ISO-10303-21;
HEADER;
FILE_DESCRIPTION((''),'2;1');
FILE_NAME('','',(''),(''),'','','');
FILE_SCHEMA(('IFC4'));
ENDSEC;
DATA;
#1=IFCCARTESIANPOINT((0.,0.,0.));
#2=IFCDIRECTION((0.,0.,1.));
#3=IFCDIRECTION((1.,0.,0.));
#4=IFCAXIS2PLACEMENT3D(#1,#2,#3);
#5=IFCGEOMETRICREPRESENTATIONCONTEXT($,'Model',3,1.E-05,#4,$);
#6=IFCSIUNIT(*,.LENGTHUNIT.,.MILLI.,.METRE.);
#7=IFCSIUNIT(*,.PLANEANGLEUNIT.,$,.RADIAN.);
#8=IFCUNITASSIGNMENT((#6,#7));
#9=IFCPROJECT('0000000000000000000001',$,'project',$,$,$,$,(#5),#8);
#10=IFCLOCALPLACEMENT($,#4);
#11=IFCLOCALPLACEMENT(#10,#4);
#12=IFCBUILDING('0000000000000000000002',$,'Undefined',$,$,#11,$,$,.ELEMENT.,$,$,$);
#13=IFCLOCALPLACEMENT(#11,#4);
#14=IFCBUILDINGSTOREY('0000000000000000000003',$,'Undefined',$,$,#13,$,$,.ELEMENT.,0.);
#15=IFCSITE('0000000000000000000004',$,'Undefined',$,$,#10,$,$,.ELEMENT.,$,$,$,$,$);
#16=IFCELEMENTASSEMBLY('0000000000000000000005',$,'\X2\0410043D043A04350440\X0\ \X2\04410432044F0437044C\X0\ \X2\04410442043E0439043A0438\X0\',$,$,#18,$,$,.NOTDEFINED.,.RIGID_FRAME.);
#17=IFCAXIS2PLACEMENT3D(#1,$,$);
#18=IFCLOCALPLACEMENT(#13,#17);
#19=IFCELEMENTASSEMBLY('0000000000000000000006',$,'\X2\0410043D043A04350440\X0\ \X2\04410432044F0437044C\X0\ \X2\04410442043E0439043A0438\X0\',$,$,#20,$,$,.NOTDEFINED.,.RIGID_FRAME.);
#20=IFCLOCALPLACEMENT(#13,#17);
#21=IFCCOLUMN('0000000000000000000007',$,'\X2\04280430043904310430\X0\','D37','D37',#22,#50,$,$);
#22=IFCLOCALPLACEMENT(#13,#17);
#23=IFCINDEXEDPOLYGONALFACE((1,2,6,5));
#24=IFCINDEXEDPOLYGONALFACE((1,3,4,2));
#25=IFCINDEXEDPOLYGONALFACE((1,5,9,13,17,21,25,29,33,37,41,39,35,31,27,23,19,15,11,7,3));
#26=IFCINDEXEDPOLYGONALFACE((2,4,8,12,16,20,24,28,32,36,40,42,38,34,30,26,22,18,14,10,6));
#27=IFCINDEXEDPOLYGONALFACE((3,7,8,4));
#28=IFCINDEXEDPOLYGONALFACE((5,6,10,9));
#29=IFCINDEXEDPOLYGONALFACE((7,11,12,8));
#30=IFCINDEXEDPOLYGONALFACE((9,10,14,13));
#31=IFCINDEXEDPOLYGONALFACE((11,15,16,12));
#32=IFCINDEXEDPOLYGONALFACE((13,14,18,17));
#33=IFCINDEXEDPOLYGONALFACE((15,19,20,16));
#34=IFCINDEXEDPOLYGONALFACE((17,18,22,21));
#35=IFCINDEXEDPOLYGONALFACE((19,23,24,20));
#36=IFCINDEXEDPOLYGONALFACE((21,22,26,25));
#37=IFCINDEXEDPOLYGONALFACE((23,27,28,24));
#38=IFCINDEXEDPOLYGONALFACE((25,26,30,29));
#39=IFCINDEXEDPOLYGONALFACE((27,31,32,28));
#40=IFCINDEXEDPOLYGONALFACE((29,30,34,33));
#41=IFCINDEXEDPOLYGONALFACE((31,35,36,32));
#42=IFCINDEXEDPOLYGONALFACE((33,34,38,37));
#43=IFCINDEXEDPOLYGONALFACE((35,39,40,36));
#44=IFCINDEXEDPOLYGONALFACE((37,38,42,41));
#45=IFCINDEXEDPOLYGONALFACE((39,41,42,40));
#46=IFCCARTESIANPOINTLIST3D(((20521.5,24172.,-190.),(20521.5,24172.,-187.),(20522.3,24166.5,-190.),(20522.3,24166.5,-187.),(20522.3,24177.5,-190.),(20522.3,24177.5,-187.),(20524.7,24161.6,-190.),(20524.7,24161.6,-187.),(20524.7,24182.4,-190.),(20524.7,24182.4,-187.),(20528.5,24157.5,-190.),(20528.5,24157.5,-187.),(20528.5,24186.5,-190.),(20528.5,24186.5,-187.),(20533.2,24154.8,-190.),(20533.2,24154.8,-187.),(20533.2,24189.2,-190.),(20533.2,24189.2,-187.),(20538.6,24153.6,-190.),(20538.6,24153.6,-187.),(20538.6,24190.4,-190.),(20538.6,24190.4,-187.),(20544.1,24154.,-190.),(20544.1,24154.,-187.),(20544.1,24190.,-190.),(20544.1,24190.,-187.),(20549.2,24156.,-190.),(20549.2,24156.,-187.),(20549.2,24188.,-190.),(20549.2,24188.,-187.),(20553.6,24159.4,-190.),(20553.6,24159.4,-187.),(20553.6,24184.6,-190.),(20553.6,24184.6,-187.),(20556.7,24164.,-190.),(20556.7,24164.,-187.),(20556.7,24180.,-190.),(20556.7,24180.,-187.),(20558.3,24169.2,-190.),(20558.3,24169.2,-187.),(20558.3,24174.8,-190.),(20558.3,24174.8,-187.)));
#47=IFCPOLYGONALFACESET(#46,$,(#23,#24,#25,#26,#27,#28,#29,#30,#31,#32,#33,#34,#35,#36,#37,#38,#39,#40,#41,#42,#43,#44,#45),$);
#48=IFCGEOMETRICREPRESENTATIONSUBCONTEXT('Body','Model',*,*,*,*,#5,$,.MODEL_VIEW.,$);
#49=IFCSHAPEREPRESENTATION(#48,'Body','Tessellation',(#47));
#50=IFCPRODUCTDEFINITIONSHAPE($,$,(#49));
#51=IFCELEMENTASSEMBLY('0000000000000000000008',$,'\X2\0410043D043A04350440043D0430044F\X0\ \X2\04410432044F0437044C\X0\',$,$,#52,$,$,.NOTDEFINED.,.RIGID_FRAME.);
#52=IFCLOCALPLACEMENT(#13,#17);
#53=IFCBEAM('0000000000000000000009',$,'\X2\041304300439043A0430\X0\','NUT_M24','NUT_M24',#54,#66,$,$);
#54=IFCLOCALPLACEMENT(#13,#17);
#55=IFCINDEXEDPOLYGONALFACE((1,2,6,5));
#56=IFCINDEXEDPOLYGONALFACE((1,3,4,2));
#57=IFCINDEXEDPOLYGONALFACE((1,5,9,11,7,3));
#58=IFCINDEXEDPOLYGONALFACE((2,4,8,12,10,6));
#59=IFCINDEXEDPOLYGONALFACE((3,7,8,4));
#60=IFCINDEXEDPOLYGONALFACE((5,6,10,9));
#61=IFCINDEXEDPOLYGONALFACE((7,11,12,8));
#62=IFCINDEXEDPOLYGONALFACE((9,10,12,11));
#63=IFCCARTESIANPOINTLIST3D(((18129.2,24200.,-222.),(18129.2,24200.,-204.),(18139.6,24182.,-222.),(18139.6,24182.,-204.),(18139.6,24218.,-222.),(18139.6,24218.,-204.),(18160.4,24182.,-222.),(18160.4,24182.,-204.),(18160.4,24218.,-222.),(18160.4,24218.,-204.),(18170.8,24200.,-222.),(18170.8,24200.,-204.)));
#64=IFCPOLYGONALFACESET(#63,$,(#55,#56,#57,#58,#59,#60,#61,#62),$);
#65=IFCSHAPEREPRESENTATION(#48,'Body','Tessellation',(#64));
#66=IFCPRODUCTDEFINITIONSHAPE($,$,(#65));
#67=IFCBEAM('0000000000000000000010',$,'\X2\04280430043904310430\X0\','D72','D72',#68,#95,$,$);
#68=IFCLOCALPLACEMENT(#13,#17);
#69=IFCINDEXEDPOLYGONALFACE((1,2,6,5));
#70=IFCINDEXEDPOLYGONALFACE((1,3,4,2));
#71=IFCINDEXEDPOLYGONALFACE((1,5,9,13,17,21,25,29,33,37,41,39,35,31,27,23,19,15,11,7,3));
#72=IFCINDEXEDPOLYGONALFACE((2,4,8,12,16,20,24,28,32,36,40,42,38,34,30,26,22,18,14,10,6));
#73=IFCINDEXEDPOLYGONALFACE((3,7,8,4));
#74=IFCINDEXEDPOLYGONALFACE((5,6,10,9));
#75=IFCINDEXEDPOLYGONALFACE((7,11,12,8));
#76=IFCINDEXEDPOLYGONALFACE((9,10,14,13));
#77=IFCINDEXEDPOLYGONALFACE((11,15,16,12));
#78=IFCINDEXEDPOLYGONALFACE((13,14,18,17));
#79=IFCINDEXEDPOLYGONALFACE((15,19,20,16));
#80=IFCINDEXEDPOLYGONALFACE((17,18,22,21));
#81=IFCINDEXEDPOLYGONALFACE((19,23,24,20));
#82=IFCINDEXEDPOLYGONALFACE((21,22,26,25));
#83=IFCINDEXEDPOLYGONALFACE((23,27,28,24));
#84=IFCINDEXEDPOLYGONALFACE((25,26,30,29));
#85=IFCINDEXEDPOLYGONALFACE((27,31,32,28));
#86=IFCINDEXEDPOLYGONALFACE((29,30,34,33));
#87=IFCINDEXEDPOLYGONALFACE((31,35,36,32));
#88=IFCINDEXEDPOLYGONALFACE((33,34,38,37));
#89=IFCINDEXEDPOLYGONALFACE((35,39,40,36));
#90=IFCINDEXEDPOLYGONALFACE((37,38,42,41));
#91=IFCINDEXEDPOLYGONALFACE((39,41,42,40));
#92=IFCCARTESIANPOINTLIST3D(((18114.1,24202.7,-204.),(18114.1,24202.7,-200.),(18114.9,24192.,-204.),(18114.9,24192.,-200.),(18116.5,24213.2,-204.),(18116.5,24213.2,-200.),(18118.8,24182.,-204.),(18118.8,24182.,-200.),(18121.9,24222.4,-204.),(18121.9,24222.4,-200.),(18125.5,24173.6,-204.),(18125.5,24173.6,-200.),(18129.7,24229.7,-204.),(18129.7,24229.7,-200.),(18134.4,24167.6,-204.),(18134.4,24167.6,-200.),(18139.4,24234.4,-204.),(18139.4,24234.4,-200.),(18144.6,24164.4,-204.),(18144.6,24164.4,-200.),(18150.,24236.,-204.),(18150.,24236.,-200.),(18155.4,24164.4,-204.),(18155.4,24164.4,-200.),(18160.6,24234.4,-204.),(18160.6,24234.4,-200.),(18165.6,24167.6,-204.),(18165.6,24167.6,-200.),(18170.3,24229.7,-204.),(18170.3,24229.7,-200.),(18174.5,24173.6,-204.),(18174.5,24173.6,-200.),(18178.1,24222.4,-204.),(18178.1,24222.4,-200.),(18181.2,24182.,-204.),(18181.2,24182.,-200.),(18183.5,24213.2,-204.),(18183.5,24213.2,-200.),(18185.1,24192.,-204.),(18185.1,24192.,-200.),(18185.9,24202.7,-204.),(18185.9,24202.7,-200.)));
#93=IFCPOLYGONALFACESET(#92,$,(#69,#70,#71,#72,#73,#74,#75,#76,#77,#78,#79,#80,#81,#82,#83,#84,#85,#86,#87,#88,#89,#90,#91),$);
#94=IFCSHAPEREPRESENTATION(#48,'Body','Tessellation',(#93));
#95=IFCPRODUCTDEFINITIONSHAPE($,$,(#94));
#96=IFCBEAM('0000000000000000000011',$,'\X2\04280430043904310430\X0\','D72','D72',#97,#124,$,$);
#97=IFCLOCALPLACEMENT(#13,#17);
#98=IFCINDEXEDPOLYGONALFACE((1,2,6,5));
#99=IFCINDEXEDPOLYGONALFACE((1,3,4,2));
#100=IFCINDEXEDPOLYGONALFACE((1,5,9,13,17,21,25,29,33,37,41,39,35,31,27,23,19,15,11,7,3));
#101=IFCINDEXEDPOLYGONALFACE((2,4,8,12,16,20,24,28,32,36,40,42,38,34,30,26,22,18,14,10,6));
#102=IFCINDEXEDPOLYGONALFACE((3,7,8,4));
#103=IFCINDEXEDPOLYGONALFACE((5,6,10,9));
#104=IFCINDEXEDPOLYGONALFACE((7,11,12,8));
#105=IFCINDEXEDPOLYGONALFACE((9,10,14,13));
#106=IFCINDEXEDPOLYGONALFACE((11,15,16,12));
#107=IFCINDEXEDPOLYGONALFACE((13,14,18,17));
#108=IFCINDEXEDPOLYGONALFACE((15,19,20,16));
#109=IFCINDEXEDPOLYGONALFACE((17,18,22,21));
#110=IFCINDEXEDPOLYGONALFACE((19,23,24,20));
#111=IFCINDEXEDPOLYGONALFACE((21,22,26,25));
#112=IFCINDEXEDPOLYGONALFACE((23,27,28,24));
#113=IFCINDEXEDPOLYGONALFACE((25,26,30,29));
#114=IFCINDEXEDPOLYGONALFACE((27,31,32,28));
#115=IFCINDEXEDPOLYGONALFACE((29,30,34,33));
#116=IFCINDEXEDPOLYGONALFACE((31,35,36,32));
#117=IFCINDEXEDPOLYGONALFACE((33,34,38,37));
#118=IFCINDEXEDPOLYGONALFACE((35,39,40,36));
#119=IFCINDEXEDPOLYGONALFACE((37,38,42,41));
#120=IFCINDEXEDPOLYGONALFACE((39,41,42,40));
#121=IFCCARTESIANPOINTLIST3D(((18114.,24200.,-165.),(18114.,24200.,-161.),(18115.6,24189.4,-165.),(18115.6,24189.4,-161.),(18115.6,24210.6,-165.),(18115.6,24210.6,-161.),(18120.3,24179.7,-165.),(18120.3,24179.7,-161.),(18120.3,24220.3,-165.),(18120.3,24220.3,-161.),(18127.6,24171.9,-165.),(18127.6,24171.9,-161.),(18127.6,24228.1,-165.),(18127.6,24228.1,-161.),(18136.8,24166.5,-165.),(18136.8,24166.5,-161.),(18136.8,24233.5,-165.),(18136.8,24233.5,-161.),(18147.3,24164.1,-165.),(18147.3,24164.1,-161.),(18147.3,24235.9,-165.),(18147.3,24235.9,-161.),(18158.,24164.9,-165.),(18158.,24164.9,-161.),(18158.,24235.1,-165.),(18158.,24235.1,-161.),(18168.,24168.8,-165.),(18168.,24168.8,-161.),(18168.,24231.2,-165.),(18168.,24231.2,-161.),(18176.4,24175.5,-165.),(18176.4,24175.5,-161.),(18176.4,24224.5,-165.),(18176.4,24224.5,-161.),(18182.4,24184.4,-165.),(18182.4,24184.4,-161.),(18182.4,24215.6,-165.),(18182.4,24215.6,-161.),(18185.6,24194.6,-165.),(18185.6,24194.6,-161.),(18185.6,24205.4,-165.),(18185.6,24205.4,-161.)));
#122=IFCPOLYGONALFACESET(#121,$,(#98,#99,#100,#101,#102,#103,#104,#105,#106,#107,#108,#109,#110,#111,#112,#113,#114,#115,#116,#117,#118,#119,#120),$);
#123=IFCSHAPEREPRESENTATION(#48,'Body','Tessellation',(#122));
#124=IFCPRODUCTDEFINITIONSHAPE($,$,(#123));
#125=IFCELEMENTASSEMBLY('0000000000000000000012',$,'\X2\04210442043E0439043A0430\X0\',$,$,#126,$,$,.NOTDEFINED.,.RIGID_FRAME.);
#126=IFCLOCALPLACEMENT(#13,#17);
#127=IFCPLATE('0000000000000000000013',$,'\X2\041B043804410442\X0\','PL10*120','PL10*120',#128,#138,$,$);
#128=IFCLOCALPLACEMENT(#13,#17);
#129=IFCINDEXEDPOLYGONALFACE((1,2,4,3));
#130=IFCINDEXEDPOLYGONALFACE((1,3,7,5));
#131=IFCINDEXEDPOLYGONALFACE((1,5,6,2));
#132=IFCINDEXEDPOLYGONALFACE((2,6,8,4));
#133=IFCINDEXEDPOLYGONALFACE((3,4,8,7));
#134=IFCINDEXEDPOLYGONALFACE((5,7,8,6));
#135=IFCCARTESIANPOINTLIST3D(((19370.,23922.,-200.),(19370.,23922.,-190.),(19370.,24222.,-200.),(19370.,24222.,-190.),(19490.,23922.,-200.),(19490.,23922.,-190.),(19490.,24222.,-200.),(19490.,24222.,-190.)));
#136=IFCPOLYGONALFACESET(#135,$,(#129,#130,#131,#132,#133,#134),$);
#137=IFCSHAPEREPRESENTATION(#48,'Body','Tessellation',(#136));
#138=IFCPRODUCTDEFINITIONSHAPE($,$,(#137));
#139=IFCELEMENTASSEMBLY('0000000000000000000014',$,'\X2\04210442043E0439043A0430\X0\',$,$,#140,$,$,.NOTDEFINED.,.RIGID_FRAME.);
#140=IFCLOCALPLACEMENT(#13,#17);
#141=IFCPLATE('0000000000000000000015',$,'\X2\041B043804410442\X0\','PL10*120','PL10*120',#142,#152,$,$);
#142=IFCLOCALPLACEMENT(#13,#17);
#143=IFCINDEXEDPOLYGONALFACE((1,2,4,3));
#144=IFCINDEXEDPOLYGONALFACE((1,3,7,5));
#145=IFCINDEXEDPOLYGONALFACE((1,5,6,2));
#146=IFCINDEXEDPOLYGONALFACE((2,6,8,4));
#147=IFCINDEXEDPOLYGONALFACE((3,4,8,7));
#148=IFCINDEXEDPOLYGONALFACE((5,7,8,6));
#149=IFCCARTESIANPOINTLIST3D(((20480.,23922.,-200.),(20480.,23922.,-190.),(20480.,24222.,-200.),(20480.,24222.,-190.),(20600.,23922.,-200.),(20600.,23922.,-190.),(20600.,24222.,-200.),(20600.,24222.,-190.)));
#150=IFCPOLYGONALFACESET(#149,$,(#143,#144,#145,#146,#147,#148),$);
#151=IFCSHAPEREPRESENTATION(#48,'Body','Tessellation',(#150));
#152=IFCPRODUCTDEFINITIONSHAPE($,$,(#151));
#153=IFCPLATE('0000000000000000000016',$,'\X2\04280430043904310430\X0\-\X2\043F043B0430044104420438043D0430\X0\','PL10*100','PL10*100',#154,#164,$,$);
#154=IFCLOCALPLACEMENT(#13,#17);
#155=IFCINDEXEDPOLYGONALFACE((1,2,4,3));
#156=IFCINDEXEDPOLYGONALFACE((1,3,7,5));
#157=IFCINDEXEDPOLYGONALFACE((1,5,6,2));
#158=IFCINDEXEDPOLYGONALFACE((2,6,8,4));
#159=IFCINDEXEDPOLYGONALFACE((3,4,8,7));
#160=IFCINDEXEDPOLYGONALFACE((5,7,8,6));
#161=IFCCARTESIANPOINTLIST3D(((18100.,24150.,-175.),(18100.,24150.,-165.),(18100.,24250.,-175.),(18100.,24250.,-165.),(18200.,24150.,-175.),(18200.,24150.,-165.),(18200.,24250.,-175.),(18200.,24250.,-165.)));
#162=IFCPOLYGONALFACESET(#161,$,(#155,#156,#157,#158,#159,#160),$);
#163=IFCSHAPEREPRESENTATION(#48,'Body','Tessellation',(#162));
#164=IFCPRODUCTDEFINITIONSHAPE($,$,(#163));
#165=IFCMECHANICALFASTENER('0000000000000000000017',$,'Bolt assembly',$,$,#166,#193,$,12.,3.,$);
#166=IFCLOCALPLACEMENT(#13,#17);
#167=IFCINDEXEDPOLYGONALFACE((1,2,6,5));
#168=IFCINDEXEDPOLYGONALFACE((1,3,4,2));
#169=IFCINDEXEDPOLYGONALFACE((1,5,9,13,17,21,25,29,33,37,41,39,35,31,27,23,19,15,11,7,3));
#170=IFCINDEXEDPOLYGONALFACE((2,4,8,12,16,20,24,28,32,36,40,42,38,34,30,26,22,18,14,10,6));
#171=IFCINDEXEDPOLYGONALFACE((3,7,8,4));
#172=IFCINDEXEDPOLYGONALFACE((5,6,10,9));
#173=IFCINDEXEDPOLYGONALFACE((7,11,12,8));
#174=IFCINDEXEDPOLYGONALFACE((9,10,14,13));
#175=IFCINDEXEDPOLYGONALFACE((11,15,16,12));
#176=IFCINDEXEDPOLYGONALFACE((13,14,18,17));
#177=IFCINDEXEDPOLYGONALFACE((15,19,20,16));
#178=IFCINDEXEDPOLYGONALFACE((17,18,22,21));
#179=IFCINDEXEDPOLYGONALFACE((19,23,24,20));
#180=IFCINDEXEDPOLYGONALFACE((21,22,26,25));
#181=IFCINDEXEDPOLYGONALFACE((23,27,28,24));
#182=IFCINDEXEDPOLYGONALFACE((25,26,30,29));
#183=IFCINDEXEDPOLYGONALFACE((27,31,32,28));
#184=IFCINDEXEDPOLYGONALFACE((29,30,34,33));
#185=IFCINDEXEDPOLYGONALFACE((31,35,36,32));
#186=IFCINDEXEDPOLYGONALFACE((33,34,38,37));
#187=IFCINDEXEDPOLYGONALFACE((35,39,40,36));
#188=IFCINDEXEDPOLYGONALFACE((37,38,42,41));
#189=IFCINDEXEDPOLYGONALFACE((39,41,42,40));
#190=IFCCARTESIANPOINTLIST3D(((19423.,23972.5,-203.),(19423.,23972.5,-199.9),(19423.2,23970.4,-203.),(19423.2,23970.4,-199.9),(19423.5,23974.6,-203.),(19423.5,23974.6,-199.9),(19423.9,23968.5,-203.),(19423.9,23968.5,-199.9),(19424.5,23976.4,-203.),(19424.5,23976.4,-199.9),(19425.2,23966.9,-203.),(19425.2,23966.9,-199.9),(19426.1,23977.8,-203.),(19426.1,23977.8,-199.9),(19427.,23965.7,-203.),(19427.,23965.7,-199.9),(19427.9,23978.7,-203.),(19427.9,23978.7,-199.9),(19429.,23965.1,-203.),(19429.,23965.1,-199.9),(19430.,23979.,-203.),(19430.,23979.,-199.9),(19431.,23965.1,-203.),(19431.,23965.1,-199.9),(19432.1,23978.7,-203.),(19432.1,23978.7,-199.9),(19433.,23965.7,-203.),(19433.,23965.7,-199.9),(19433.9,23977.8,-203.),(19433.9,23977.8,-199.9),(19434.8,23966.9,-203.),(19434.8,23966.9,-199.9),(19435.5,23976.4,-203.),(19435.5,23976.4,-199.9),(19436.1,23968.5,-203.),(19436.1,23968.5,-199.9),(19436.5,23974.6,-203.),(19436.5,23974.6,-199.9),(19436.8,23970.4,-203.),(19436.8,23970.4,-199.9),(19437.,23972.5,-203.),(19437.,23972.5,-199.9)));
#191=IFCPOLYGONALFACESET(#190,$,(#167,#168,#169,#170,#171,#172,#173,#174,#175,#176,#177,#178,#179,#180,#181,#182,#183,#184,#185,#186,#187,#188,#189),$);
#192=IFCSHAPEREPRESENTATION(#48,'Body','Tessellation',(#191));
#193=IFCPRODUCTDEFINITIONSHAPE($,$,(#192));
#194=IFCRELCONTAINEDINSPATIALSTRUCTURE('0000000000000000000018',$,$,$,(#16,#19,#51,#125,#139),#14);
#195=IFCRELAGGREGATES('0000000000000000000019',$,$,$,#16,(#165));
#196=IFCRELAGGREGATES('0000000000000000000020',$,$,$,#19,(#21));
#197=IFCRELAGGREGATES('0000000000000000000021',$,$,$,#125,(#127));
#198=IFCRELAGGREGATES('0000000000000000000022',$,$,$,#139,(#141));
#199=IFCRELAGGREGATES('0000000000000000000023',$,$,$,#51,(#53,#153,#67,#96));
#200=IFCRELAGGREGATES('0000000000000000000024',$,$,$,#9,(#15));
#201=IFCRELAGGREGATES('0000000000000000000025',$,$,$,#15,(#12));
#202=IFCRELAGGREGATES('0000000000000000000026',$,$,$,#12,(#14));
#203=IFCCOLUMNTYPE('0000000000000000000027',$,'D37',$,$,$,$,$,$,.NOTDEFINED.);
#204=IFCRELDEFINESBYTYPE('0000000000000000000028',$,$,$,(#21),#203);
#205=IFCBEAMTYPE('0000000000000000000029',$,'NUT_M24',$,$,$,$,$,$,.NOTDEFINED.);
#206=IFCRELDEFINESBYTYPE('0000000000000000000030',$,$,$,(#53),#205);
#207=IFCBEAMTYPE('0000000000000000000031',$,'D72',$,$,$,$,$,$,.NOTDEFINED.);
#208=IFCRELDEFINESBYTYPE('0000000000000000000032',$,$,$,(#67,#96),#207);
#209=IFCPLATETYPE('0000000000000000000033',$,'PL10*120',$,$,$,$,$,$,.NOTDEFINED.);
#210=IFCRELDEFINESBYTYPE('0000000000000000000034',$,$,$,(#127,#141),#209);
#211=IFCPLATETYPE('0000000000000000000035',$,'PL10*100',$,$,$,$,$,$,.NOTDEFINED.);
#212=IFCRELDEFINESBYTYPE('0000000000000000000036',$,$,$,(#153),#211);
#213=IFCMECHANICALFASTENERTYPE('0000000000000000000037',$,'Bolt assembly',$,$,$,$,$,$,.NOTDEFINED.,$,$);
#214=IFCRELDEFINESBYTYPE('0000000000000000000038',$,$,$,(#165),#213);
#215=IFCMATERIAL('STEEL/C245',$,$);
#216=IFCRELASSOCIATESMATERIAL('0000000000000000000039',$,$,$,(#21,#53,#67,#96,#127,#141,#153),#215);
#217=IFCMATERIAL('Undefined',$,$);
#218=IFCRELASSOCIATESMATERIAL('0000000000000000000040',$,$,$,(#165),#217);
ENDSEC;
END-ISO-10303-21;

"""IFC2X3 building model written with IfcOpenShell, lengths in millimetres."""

from ifc_helpers import new_model, si_unit, frame, origin_with_axes, origin_2d_with_axis, place, context, subcontext, project, spatial, polyline, circle, outline, extrude, source, transform, mapped, material, type_object, element, aggregate, save


model = new_model("IFC2X3")

# Units and contexts
model_context = context("Model", 3, precision=1e-05, world=origin_with_axes())
body_context = subcontext(model_context, "Body", "Model", "MODEL_VIEW")
ifc_project = project(units=[si_unit("LENGTHUNIT", "METRE", prefix="MILLI"), si_unit("PLANEANGLEUNIT", "RADIAN")], contexts=[model_context])

# Site, building, storey
site_placement = place(None, origin_with_axes())
site = spatial("IfcSite", under=ifc_project, at=site_placement, Name="Undefined", CompositionType="ELEMENT")
building_placement = place(site_placement, origin_with_axes())
building = spatial("IfcBuilding", under=site, at=building_placement, Name="Undefined", CompositionType="ELEMENT")
storey_placement = place(building_placement, origin_with_axes())
storey = spatial("IfcBuildingStorey", under=building, at=storey_placement, Name="Undefined", CompositionType="ELEMENT", Elevation=0.0)

# Element assemblies
assembly_1_placement = place(storey_placement, origin_with_axes())
assembly_1 = element("IfcElementAssembly", 1, at=assembly_1_placement, inside=storey, Name="Анкер связь стойки", AssemblyPlace="NOTDEFINED", PredefinedType="RIGID_FRAME")
ifc_material_1 = material(Name="STEEL/C245")
assembly_2_placement = place(storey_placement, origin_with_axes())
assembly_2 = element("IfcElementAssembly", 2, at=assembly_2_placement, inside=storey, Name="Анкер связь стойки", AssemblyPlace="NOTDEFINED", PredefinedType="RIGID_FRAME")

# Column
column_type_1 = type_object("IfcColumnType", Name="D37", PredefinedType="NOTDEFINED")
column_1_placement = place(assembly_2_placement, frame((20540.0, 24172.0, -187.0), z_axis=(0.0, 0.0, -1.0), x_axis=(0.0, -1.0, 0.0)))
column_1 = element("IfcColumn", 3, at=column_1_placement, type_object=column_type_1, material=ifc_material_1, Name="Шайба", Description="D37", ObjectType="D37", context=body_context, shape_type="SweptSolid", body=[
    extrude(circle(Radius=18.5, at=origin_2d_with_axis()), frame((0.0, 0.0, 3.0), z_axis=(0.0, 0.0, -1.0), x_axis=(0.0, 1.0, 0.0)), (0.0, 0.0, 1.0), 3.0),
])

# Element assembly, beams
assembly_3_placement = place(storey_placement, origin_with_axes())
assembly_3 = element("IfcElementAssembly", 4, at=assembly_3_placement, inside=storey, Name="Анкерная связь", AssemblyPlace="NOTDEFINED", PredefinedType="RIGID_FRAME")
beam_type_1 = type_object("IfcBeamType", Name="NUT_M24", PredefinedType="NOTDEFINED")
beam_1_placement = place(assembly_3_placement, frame((18150.0, 24200.0, -204.0), z_axis=(0.0, 1.0, 0.0), x_axis=(0.0, 0.0, -1.0)))
beam_1 = element("IfcBeam", 5, at=beam_1_placement, type_object=beam_type_1, material=ifc_material_1, Name="Гайка", Description="NUT_M24", ObjectType="NUT_M24", context=body_context, shape_type="SweptSolid", body=[
    extrude(outline(polyline([(-10.4, 18.0), (10.4, 18.0), (20.8, 0.0), (10.4, -18.0), (-10.4, -18.0), (-20.8, 0.0), (-10.4, 18.0)])), frame((18.0, 0.0, 0.0), z_axis=(-1.0, 0.0, 0.0), x_axis=(0.0, -1.0, 0.0)), (0.0, 0.0, 1.0), 18.0),
])
beam_type_2 = type_object("IfcBeamType", Name="D72", PredefinedType="NOTDEFINED")
beam_2_placement = place(assembly_3_placement, frame((18150.0, 24200.0, -200.0), z_axis=(-1.0, 0.0, 0.0), x_axis=(0.0, 0.0, -1.0)))
beam_2 = element("IfcBeam", 6, at=beam_2_placement, type_object=beam_type_2, material=ifc_material_1, Name="Шайба", Description="D72", ObjectType="D72", context=body_context, shape_type="SweptSolid", body=[
    extrude(circle(Radius=36.0, at=origin_2d_with_axis()), frame((4.0, 0.0, 0.0), z_axis=(-1.0, 0.0, 0.0), x_axis=(0.0, -1.0, 0.0)), (0.0, 0.0, 1.0), 4.0),
])
beam_3_placement = place(assembly_3_placement, frame((18150.0, 24200.0, -161.0), z_axis=(0.0, -1.0, 0.0), x_axis=(0.0, 0.0, -1.0)))
beam_3 = element("IfcBeam", 7, at=beam_3_placement, type_object=beam_type_2, material=ifc_material_1, Name="Шайба", Description="D72", ObjectType="D72", context=body_context, shape_type="SweptSolid", body=[
    extrude(circle(Radius=36.0, at=origin_2d_with_axis()), frame((4.0, 0.0, 0.0), z_axis=(-1.0, 0.0, 0.0), x_axis=(0.0, -1.0, 0.0)), (0.0, 0.0, 1.0), 4.0),
])

# Element assemblies, plates
assembly_4_placement = place(storey_placement, origin_with_axes())
assembly_4 = element("IfcElementAssembly", 8, at=assembly_4_placement, inside=storey, Name="Стойка", AssemblyPlace="NOTDEFINED", PredefinedType="RIGID_FRAME")
plate_type_1 = type_object("IfcPlateType", Name="PL10*120", PredefinedType="NOTDEFINED")
plate_1_placement = place(assembly_4_placement, frame((19430.0, 23922.0, -195.0), z_axis=(0.0, 0.0, 1.0), x_axis=(0.0, 1.0, 0.0)))
plate_1 = element("IfcPlate", 9, at=plate_1_placement, type_object=plate_type_1, material=ifc_material_1, Name="Лист", Description="PL10*120", ObjectType="PL10*120", context=body_context, shape_type="SweptSolid", body=[
    extrude(outline(polyline([(0.0, 60.0), (300.0, 60.0), (300.0, -60.0), (0.0, -60.0), (0.0, 60.0)])), frame((0.0, 0.0, -5.0), z_axis=(0.0, 0.0, 1.0), x_axis=(1.0, 0.0, 0.0)), (0.0, 0.0, 1.0), 10.0),
])
assembly_5_placement = place(storey_placement, origin_with_axes())
assembly_5 = element("IfcElementAssembly", 10, at=assembly_5_placement, inside=storey, Name="Стойка", AssemblyPlace="NOTDEFINED", PredefinedType="RIGID_FRAME")
plate_2_placement = place(assembly_5_placement, frame((20540.0, 23922.0, -195.0), z_axis=(0.0, 0.0, 1.0), x_axis=(0.0, 1.0, 0.0)))
plate_2 = element("IfcPlate", 11, at=plate_2_placement, type_object=plate_type_1, material=ifc_material_1, Name="Лист", Description="PL10*120", ObjectType="PL10*120", context=body_context, shape_type="SweptSolid", body=[
    extrude(outline(polyline([(0.0, 60.0), (300.0, 60.0), (300.0, -60.0), (0.0, -60.0), (0.0, 60.0)])), frame((0.0, 0.0, -5.0), z_axis=(0.0, 0.0, 1.0), x_axis=(1.0, 0.0, 0.0)), (0.0, 0.0, 1.0), 10.0),
])

# Plate
plate_type_2 = type_object("IfcPlateType", Name="PL10*100", PredefinedType="NOTDEFINED")
plate_3_placement = place(assembly_3_placement, frame((18200.0, 24250.0, -170.0), z_axis=(0.0, 0.0, -1.0), x_axis=(0.0, -1.0, 0.0)))
plate_3 = element("IfcPlate", 12, at=plate_3_placement, type_object=plate_type_2, material=ifc_material_1, Name="Шайба-пластина", Description="PL10*100", ObjectType="PL10*100", context=body_context, shape_type="SweptSolid", body=[
    extrude(outline(polyline([(0.0, 0.0), (100.0, 0.0), (100.0, 100.0), (0.0, 100.0), (0.0, 0.0)])), frame((0.0, 0.0, -5.0), z_axis=(0.0, 0.0, 1.0), x_axis=(1.0, 0.0, 0.0)), (0.0, 0.0, 1.0), 10.0),
])

# Mechanical fastener
ifc_material_2 = material(Name="Undefined")
mechanical_fastener_type = type_object("IfcMechanicalFastenerType", Name="Bolt assembly")
shared_shape_1 = source(origin_with_axes(), body_context, "Body", "SweptSolid", [
    extrude(circle(Radius=7.0, at=origin_2d_with_axis()), frame((0.0, -3.0, 0.0), z_axis=(0.0, 1.0, 0.0), x_axis=(1.0, 0.0, 0.0)), (0.0, 0.0, 1.0), 3.1),
])
mechanical_fastener_1_placement = place(assembly_1_placement, frame((19430.0, 23972.0, -200.0), z_axis=(1.0, 0.0, 0.0), x_axis=(0.0, 1.0, 0.0)))
mechanical_fastener_1 = element("IfcMechanicalFastener", 13, at=mechanical_fastener_1_placement, type_object=mechanical_fastener_type, material=ifc_material_2, Name="Bolt assembly", NominalDiameter=12.0, NominalLength=3.0, context=body_context, shape_type="MappedRepresentation", body=[
    mapped(shared_shape_1, transform((0.0, 0.0, 0.0))),
])
aggregate(assembly_1, [mechanical_fastener_1])
aggregate(assembly_2, [column_1])
aggregate(assembly_4, [plate_1])
aggregate(assembly_5, [plate_2])
aggregate(assembly_3, [beam_1, plate_3, beam_2, beam_3])

save(model, "model.ifc")
